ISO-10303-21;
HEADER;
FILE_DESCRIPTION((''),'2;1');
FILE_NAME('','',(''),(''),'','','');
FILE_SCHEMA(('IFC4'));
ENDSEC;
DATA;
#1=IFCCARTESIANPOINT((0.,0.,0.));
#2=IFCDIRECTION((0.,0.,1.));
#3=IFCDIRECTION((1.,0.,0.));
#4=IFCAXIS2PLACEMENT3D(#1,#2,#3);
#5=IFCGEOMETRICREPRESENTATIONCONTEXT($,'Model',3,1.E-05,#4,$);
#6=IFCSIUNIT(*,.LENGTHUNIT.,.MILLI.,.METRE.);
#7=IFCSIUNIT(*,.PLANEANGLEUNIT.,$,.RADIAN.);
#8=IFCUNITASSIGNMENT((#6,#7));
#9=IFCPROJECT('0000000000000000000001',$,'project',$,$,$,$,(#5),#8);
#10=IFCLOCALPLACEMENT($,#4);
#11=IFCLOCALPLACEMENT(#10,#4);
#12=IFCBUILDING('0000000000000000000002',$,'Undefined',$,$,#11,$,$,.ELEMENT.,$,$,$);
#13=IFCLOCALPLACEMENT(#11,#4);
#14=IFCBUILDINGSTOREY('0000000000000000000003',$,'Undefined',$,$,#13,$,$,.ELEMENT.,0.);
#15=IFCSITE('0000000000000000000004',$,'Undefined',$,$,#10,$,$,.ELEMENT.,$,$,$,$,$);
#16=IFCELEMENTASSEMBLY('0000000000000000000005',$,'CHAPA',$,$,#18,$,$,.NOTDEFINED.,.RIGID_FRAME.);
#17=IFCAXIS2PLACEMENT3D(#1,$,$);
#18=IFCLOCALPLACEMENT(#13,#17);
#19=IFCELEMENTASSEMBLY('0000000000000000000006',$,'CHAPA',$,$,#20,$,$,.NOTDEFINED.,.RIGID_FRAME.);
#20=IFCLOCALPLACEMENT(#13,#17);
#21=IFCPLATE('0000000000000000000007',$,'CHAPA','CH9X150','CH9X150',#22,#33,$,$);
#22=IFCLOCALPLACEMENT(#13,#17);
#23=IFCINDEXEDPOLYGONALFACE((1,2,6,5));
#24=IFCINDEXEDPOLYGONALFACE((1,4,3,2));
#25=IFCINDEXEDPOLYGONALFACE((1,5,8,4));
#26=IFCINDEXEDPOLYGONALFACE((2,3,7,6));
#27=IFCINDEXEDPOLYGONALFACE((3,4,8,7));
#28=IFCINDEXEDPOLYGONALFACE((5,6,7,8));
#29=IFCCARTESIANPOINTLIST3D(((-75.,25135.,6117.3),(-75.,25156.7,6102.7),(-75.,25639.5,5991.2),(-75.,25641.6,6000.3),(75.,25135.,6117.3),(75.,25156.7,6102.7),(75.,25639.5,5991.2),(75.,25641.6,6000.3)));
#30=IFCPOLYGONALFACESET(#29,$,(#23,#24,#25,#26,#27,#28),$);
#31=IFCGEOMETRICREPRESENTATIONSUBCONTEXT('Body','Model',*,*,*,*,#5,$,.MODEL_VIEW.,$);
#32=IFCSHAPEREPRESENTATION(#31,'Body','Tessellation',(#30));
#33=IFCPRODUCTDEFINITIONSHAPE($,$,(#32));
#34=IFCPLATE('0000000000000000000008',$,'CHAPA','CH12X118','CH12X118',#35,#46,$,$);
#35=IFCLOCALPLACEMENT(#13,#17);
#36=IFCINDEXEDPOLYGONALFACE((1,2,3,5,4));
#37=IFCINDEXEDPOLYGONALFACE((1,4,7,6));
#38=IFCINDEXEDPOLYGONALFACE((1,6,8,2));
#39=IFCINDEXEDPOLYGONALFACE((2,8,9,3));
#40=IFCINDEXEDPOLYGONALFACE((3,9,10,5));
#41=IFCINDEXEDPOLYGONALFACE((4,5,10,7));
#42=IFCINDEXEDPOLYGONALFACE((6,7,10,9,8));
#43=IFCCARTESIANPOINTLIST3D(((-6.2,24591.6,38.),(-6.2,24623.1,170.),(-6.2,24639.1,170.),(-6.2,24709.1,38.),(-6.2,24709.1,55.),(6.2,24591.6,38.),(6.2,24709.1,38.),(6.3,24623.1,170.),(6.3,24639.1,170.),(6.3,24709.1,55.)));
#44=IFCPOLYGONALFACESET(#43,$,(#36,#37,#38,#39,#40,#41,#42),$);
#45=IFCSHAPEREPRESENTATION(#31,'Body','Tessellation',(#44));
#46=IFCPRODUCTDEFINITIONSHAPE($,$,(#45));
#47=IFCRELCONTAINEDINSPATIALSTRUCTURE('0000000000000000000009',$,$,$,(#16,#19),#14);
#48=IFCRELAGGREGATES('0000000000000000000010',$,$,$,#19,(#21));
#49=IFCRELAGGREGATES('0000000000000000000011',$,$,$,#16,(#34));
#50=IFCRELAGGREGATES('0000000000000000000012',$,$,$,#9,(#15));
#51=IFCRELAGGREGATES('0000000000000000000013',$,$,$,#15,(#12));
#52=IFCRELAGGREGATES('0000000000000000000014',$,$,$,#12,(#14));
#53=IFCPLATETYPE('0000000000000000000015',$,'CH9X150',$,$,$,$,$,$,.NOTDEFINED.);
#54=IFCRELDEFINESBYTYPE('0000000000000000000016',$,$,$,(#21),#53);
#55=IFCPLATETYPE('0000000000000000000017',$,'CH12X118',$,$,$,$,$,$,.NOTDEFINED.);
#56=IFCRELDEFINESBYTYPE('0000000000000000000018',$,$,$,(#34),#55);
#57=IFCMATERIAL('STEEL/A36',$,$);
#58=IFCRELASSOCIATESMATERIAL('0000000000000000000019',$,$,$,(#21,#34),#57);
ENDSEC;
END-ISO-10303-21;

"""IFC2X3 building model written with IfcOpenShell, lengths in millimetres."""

from ifc_helpers import new_model, si_unit, frame, origin_with_axes, place, context, subcontext, project, spatial, polyline, outline, extrude, clip, halfspace, material, type_object, element, aggregate, save


model = new_model("IFC2X3")

# Units and contexts
model_context = context("Model", 3, precision=1e-05, world=origin_with_axes())
body_context = subcontext(model_context, "Body", "Model", "MODEL_VIEW")
ifc_project = project(units=[si_unit("LENGTHUNIT", "METRE", prefix="MILLI"), si_unit("PLANEANGLEUNIT", "RADIAN")], contexts=[model_context])

# Site, building, storey
site_placement = place(None, origin_with_axes())
site = spatial("IfcSite", under=ifc_project, at=site_placement, Name="Undefined", CompositionType="ELEMENT")
building_placement = place(site_placement, origin_with_axes())
building = spatial("IfcBuilding", under=site, at=building_placement, Name="Undefined", CompositionType="ELEMENT")
storey_placement = place(building_placement, origin_with_axes())
storey = spatial("IfcBuildingStorey", under=building, at=storey_placement, Name="Undefined", CompositionType="ELEMENT", Elevation=0.0)

# Element assembly
ifc_material_1 = material(Name="STEEL/A36")
assembly_1_placement = place(storey_placement, origin_with_axes())
assembly_1 = element("IfcElementAssembly", 1, at=assembly_1_placement, inside=storey, Name="CHAPA", AssemblyPlace="NOTDEFINED", PredefinedType="RIGID_FRAME")

# Element assembly, plate
plate_type_1 = type_object("IfcPlateType", Name="CH9X150", PredefinedType="NOTDEFINED")
assembly_2_placement = place(storey_placement, origin_with_axes())
assembly_2 = element("IfcElementAssembly", 2, at=assembly_2_placement, inside=storey, Name="CHAPA", AssemblyPlace="NOTDEFINED", PredefinedType="RIGID_FRAME")
plate_1_placement = place(assembly_2_placement, frame((75.0, 25640.6, 5995.7), z_axis=(0.0, -0.225124, -0.97433), x_axis=(0.0, -0.97433, 0.225124)))
plate_1 = element("IfcPlate", 3, at=plate_1_placement, type_object=plate_type_1, material=ifc_material_1, Name="CHAPA", Description="CH9X150", ObjectType="CH9X150", context=body_context, shape_type="Clipping", body=[
    clip(extrude(outline(polyline([(0.0, 0.0), (520.0, 0.0), (520.0, 150.0), (0.0, 150.0), (0.0, 0.0)])), frame((0.0, 0.0, -4.7), z_axis=(0.0, 0.0, 1.0), x_axis=(1.0, 0.0, 0.0)), (0.0, 0.0, 1.0), 9.3), halfspace(frame((520.0, -500.0, -4.7), z_axis=(0.354778, 0.0, 0.934951), x_axis=(-0.934951, 0.0, 0.354778)), False)),
])
aggregate(assembly_2, [plate_1])

# Plate
plate_type_2 = type_object("IfcPlateType", Name="CH12X118", PredefinedType="NOTDEFINED")
plate_2_placement = place(assembly_1_placement, frame((0.0, 24709.1, 38.0), z_axis=(-1.0, 0.0, 0.0), x_axis=(0.0, -1.0, 0.0)))
plate_2 = element("IfcPlate", 4, at=plate_2_placement, type_object=plate_type_2, material=ifc_material_1, Name="CHAPA", Description="CH12X118", ObjectType="CH12X118", context=body_context, shape_type="SweptSolid", body=[
    extrude(outline(polyline([(0.0, 0.0), (117.5, 0.0), (85.9, 132.0), (70.0, 132.0), (0.0, 17.0), (0.0, 0.0)])), frame((0.0, 0.0, -6.2), z_axis=(0.0, 0.0, 1.0), x_axis=(1.0, 0.0, 0.0)), (0.0, 0.0, 1.0), 12.5),
])

aggregate(assembly_1, [plate_2])

save(model, "model.ifc")
